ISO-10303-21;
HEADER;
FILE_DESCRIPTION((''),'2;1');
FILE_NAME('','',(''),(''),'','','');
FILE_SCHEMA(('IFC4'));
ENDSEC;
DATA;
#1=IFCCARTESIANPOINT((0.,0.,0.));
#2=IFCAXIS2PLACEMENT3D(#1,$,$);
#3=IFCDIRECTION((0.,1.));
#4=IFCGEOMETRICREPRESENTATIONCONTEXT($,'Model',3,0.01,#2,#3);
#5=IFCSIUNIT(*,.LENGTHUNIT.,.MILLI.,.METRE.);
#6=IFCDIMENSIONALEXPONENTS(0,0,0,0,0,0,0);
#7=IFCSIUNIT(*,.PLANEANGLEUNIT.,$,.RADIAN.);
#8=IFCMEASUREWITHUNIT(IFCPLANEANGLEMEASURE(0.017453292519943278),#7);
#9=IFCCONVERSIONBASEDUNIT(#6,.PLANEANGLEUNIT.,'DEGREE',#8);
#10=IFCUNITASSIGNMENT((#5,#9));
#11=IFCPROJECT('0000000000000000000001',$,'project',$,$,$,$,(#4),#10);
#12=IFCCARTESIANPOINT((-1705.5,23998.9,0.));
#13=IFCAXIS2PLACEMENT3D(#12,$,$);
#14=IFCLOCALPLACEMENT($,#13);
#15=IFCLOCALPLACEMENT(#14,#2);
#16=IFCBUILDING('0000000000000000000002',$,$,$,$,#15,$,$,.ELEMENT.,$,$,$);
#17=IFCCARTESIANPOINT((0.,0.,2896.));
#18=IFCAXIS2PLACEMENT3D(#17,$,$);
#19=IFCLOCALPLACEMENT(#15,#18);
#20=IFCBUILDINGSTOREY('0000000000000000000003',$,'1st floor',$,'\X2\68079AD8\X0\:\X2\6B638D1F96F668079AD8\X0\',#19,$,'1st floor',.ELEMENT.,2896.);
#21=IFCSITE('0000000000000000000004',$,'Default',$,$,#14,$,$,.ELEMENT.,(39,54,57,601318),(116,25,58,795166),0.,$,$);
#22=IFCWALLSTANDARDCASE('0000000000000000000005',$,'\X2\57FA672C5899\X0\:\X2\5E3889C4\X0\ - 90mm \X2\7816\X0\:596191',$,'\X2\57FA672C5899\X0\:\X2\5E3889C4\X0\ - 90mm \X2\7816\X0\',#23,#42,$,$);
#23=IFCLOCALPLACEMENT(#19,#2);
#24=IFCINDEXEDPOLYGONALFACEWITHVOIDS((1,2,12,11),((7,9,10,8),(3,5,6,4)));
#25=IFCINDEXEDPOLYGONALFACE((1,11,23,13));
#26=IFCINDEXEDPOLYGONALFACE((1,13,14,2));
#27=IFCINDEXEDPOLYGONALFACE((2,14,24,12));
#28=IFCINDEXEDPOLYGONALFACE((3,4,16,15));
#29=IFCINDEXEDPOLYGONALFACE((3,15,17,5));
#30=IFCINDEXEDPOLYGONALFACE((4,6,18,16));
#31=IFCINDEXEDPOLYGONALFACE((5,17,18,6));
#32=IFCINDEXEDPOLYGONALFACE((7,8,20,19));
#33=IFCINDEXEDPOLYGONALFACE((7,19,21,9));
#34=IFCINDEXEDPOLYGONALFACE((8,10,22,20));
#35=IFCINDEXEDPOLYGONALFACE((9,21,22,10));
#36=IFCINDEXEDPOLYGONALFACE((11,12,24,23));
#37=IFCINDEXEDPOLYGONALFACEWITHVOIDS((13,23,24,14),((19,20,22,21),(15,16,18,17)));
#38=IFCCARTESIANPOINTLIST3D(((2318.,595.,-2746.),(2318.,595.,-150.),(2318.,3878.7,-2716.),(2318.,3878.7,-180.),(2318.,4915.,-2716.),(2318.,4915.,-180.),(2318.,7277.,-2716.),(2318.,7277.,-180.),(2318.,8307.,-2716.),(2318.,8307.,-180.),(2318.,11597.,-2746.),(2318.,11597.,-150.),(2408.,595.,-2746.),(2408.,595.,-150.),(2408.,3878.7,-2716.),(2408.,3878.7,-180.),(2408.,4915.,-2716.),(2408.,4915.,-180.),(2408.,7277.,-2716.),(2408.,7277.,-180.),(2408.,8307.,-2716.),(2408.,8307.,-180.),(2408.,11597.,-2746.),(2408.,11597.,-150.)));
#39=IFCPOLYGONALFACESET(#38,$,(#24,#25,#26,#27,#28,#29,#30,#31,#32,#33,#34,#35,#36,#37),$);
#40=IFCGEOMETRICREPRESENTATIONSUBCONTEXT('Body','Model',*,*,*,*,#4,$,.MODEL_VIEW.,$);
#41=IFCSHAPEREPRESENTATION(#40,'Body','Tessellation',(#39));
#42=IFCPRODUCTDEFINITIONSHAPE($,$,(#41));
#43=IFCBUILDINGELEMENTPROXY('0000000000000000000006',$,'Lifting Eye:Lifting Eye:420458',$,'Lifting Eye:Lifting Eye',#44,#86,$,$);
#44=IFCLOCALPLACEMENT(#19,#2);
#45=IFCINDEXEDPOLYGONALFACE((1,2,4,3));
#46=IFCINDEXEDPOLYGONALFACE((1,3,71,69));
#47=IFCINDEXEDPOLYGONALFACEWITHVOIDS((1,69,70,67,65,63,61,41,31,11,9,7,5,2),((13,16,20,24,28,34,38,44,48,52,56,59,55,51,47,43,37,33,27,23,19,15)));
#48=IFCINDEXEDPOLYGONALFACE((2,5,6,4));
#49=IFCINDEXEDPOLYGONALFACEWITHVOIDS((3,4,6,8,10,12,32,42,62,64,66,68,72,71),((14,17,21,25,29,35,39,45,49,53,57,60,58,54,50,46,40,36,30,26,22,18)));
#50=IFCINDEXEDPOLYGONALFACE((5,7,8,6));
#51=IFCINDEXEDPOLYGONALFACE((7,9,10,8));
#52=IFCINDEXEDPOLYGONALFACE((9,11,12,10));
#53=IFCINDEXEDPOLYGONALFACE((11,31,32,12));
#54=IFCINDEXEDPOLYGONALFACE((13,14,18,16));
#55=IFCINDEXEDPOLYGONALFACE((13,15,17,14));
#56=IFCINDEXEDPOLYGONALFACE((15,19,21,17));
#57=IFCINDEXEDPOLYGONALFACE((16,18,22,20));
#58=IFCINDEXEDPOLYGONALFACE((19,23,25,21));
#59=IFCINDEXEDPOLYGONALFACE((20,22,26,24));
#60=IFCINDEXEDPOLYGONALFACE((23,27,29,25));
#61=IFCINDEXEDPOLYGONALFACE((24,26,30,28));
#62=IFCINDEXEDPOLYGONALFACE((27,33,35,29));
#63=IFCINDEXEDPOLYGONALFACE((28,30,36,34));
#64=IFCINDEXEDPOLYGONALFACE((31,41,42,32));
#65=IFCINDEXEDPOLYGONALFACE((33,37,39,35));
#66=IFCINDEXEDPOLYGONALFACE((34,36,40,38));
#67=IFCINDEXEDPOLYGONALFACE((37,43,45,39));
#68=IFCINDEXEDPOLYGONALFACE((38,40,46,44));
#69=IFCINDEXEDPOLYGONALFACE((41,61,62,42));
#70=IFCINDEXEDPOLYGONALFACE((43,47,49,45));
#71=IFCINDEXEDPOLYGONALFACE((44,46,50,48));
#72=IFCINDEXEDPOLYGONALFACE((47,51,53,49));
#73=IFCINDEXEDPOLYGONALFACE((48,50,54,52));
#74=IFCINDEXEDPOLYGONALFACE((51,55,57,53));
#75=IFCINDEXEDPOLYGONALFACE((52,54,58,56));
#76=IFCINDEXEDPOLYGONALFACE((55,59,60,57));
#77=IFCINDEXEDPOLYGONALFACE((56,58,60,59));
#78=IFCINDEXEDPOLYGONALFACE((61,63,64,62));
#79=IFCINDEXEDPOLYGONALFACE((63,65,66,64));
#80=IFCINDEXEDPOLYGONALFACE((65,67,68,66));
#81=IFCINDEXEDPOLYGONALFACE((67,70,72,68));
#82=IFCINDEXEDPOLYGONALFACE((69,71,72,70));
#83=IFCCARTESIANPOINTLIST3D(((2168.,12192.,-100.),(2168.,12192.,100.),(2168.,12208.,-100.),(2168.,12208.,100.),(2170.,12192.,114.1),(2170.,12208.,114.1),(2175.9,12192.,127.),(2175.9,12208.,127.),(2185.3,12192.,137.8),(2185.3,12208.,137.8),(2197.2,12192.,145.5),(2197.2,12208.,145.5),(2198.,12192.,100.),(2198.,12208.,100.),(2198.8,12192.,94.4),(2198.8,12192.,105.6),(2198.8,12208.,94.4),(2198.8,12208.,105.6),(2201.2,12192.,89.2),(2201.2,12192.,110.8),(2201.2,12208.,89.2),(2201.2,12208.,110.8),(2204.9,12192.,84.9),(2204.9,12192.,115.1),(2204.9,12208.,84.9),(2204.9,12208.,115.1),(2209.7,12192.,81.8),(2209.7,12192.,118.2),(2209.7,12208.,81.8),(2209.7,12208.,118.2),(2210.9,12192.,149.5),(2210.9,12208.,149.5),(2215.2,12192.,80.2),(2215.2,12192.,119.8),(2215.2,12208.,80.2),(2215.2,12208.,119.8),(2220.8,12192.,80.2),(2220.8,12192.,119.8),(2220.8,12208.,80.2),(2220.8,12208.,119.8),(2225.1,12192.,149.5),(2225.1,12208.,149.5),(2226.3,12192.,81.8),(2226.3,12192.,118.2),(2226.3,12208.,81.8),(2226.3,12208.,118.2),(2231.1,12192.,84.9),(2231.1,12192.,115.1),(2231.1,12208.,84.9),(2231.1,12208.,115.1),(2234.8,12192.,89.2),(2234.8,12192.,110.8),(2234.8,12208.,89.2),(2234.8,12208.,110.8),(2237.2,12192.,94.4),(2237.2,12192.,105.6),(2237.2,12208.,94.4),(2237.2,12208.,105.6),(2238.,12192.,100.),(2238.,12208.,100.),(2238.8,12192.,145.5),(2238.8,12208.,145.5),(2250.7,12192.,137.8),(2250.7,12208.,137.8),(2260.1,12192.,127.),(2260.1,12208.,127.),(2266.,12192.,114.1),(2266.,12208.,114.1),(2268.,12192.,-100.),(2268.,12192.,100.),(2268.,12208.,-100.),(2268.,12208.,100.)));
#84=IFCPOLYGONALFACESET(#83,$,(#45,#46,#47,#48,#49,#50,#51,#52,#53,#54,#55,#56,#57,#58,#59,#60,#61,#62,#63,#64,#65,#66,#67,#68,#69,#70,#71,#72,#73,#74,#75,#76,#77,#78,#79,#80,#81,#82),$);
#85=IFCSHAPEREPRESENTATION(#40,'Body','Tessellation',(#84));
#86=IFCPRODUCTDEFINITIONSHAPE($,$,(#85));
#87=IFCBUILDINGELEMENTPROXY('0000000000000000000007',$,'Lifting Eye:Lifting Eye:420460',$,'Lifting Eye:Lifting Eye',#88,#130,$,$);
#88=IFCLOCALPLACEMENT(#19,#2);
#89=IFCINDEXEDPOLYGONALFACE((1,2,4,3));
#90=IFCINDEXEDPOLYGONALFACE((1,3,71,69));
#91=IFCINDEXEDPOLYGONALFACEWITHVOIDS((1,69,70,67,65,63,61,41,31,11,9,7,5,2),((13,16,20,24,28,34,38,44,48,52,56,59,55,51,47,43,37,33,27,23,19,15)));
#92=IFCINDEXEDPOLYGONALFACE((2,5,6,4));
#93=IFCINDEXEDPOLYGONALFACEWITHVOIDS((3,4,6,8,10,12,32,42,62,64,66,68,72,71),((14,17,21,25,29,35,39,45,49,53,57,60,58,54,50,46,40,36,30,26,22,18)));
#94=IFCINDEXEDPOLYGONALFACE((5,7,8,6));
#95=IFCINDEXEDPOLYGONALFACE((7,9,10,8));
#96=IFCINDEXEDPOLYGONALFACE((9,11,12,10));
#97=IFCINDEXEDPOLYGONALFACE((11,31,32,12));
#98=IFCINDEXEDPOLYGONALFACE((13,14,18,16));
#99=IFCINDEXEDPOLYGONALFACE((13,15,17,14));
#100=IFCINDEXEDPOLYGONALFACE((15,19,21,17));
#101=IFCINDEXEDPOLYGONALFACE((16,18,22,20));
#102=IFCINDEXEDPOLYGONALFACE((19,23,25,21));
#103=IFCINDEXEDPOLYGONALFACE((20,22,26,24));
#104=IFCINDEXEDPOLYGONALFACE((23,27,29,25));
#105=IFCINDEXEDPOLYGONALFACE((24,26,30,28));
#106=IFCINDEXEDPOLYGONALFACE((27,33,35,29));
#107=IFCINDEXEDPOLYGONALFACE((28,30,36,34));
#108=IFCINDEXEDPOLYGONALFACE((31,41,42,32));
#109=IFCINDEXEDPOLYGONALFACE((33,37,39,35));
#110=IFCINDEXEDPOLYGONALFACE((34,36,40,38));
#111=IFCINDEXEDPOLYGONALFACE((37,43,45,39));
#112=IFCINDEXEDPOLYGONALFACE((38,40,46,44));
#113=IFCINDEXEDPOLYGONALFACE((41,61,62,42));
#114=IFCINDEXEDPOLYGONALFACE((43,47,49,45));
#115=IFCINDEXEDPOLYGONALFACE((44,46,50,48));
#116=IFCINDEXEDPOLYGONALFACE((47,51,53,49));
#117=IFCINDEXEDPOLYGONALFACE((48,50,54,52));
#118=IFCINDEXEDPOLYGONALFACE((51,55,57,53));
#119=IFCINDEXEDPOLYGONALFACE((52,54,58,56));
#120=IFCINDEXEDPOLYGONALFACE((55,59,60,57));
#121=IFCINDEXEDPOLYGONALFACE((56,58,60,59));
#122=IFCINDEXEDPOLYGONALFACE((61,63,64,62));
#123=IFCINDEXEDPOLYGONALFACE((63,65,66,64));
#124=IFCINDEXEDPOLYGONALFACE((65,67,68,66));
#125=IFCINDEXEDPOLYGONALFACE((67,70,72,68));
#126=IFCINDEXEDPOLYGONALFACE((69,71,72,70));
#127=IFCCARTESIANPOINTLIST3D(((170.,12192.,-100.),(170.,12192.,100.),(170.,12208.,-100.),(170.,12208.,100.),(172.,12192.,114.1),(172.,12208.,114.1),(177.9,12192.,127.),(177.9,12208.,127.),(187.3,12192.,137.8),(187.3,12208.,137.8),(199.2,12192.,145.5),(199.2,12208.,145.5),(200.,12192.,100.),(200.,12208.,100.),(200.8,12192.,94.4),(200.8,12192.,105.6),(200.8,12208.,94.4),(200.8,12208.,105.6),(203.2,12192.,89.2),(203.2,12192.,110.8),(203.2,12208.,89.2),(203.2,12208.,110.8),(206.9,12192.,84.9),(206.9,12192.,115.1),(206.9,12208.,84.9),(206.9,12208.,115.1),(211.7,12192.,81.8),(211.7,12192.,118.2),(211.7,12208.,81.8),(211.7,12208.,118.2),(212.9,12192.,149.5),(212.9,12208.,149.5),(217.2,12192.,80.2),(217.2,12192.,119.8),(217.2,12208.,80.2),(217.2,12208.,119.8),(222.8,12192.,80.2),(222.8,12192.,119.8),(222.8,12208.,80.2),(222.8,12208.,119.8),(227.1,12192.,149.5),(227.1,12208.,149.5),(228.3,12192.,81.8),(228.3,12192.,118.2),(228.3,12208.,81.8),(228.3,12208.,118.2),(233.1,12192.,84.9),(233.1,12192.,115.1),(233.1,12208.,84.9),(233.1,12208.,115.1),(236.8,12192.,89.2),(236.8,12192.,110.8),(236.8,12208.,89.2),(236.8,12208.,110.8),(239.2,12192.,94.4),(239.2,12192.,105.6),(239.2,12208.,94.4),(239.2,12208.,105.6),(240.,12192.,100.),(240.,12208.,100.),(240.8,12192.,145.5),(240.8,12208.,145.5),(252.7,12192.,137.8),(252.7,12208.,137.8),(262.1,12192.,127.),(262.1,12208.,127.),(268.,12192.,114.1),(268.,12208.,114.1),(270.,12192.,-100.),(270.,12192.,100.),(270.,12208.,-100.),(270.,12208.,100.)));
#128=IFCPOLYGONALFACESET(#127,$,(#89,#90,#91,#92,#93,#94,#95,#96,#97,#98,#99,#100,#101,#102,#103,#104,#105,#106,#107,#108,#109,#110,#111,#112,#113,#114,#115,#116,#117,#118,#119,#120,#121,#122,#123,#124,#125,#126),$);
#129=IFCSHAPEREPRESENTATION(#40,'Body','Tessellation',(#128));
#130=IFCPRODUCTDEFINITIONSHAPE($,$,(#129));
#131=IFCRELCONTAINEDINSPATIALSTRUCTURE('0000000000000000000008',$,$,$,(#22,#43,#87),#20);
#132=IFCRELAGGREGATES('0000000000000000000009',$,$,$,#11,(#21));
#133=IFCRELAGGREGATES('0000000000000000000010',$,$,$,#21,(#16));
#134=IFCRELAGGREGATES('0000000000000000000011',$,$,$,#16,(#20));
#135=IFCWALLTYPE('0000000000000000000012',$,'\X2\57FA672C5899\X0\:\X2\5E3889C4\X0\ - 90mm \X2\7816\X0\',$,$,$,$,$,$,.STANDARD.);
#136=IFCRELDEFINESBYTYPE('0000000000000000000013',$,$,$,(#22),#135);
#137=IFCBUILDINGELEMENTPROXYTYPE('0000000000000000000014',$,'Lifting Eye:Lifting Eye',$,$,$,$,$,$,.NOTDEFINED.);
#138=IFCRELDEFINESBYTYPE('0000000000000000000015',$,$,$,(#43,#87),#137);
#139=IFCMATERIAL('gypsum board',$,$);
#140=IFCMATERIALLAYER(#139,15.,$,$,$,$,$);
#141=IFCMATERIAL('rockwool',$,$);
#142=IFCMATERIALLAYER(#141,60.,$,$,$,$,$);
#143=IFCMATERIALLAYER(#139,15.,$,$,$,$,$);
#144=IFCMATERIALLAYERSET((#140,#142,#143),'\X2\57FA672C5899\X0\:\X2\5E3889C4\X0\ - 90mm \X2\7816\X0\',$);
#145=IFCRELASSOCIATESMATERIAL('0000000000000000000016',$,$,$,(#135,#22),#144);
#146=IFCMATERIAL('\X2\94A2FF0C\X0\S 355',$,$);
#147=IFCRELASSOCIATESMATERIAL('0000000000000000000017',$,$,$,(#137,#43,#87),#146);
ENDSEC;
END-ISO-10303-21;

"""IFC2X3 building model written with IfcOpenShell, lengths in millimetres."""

from ifc_helpers import new_model, entity, si_unit, converted_unit, direction, frame, frame_2d, origin, place, context, subcontext, project, spatial, polyline, circle_curve, parameter, trimmed, segment, composite_curve, rectangle, outline, extrude, source, transform, mapped, material, layer, layer_set, layer_usage, type_object, type_shapes, element, save


model = new_model("IFC2X3")

# Units and contexts
model_context = context("Model", 3, precision=0.01, world=origin(), true_north=direction((0.0, 1.0)))
body_context = subcontext(model_context, "Body", "Model", "MODEL_VIEW")
ifc_project = project(units=[si_unit("LENGTHUNIT", "METRE", prefix="MILLI"), converted_unit("PLANEANGLEUNIT", "DEGREE", entity("IfcPlaneAngleMeasure", 0.017453292519943278), si_unit("PLANEANGLEUNIT", "RADIAN"), dimensions=[0, 0, 0, 0, 0, 0, 0])], contexts=[model_context])

# Site, building, storey
site_placement = place(None, frame((-1705.5, 23998.9, 0.0)))
site = spatial("IfcSite", under=ifc_project, at=site_placement, Name="Default", CompositionType="ELEMENT", RefLatitude=(39, 54, 57, 601318), RefLongitude=(116, 25, 58, 795166), RefElevation=0.0)
building_placement = place(site_placement, origin())
building = spatial("IfcBuilding", under=site, at=building_placement, CompositionType="ELEMENT")
storey_placement = place(building_placement, frame((0.0, 0.0, 2896.0)))
storey = spatial("IfcBuildingStorey", under=building, at=storey_placement, Name="1st floor", ObjectType="标高:正负零标高", LongName="1st floor", CompositionType="ELEMENT", Elevation=2896.0)

# Shared definitions
ifc_material_1 = material(Name="gypsum board")
ifc_layer_1 = layer(ifc_material_1, 15.0)
ifc_material_2 = material(Name="rockwool")
ifc_layer_2 = layer(ifc_material_2, 60.0)
ifc_layer_3 = layer(ifc_material_1, 15.0)
ifc_layer_set = layer_set([ifc_layer_1, ifc_layer_2, ifc_layer_3], Name="基本墙:常规 - 90mm 砖")
wall_type = type_object("IfcWallType", Name="基本墙:常规 - 90mm 砖", PredefinedType="STANDARD", material=ifc_layer_set)

# Wall, openings
ifc_layer_usage_1 = layer_usage(ifc_layer_set, "AXIS2", "NEGATIVE", 45.0)
wall_1_placement = place(storey_placement, frame((2363.0, 11597.0, -2746.0), z_axis=(0.0, 0.0, 1.0), x_axis=(0.0, -1.0, 0.0)))
wall_1 = element("IfcWallStandardCase", 1, at=wall_1_placement, inside=storey, type_object=wall_type, material=ifc_layer_usage_1, Name="基本墙:常规 - 90mm 砖:596191", ObjectType="基本墙:常规 - 90mm 砖", context=body_context, shape_type="SweptSolid", body=[
    extrude(rectangle(XDim=11002.0, YDim=90.0, at=frame_2d((5501.0, 0.0), x_axis=(-1.0, 0.0))), origin(), (0.0, 0.0, 1.0), 2596.0),
])
opening_1_placement = place(wall_1_placement, origin())
element("IfcOpeningElement", 2, at=opening_1_placement, cuts=wall_1, ObjectType="Opening", context=body_context, shape_type="SweptSolid", body=[
    extrude(rectangle(XDim=2536.0, YDim=1030.0, at=frame_2d((0.0, 0.0), x_axis=(0.0, 1.0))), frame((3805.0, 45.0, 1298.0), z_axis=(0.0, -1.0, 0.0), x_axis=(-1.0, 0.0, 0.0)), (0.0, 0.0, 1.0), 90.0),
])
opening_2_placement = place(wall_1_placement, origin())
element("IfcOpeningElement", 3, at=opening_2_placement, cuts=wall_1, ObjectType="Opening", context=body_context, shape_type="SweptSolid", body=[
    extrude(rectangle(XDim=2536.0, YDim=1036.3, at=frame_2d((0.0, 0.0), x_axis=(0.0, 1.0))), frame((7200.2, 45.0, 1298.0), z_axis=(0.0, -1.0, 0.0), x_axis=(-1.0, 0.0, 0.0)), (0.0, 0.0, 1.0), 90.0),
])

# Building element proxies
ifc_material_3 = material(Name="钢，S 355")
building_element_proxy_type_1 = type_object("IfcBuildingElementProxyType", Name="Lifting Eye:Lifting Eye", PredefinedType="NOTDEFINED", material=ifc_material_3)
shared_shape_1 = source(origin(), body_context, "Body", "SweptSolid", [
    extrude(outline(composite_curve([segment(polyline([(-100.0, -50.0), (100.0, -50.0)]), True, "CONTINUOUS"), segment(polyline([(100.0, -50.0), (100.0, 50.0)]), True, "CONTINUOUS"), segment(polyline([(100.0, 50.0), (-100.0, 50.0)]), True, "CONTINUOUS"), segment(trimmed(circle_curve(frame_2d((-100.0, 0.0), x_axis=(0.0, -1.0)), 50.0), [parameter(180.0)], [parameter(0.0)], True, "PARAMETER"), True, "CONTINUOUS")], self_intersect=False), holes=[composite_curve([segment(trimmed(circle_curve(frame_2d((-100.0, 0.0), x_axis=(0.0, -1.0)), 20.0), [parameter(180.0)], [parameter(360.0)], True, "PARAMETER"), False, "CONTINUOUS"), segment(trimmed(circle_curve(frame_2d((-100.0, 0.0), x_axis=(0.0, -1.0)), 20.0), [parameter(0.0)], [parameter(180.0)], True, "PARAMETER"), False, "CONTINUOUS")], self_intersect=False)]), frame((0.0, 17.0, -17.0), z_axis=(0.0, 1.0, 0.0), x_axis=(0.0, 0.0, -1.0)), (0.0, 0.0, 1.0), 16.0),
])
type_shapes(building_element_proxy_type_1, [shared_shape_1])
for number, where, name in (
    (4, (2218.0, 12175.0, 17.0), "Lifting Eye:Lifting Eye:420458"),
    (5, (220.0, 12175.0, 17.0), "Lifting Eye:Lifting Eye:420460"),
):
    element("IfcBuildingElementProxy", number, at=place(storey_placement, frame(where)), inside=storey, type_object=building_element_proxy_type_1, material=ifc_material_3, Name=name, ObjectType="Lifting Eye:Lifting Eye", context=body_context, shape_type="MappedRepresentation", body=[
        mapped(shared_shape_1, transform((0.0, 0.0, 0.0), scale=1.0)),
    ])

save(model, "model.ifc")
